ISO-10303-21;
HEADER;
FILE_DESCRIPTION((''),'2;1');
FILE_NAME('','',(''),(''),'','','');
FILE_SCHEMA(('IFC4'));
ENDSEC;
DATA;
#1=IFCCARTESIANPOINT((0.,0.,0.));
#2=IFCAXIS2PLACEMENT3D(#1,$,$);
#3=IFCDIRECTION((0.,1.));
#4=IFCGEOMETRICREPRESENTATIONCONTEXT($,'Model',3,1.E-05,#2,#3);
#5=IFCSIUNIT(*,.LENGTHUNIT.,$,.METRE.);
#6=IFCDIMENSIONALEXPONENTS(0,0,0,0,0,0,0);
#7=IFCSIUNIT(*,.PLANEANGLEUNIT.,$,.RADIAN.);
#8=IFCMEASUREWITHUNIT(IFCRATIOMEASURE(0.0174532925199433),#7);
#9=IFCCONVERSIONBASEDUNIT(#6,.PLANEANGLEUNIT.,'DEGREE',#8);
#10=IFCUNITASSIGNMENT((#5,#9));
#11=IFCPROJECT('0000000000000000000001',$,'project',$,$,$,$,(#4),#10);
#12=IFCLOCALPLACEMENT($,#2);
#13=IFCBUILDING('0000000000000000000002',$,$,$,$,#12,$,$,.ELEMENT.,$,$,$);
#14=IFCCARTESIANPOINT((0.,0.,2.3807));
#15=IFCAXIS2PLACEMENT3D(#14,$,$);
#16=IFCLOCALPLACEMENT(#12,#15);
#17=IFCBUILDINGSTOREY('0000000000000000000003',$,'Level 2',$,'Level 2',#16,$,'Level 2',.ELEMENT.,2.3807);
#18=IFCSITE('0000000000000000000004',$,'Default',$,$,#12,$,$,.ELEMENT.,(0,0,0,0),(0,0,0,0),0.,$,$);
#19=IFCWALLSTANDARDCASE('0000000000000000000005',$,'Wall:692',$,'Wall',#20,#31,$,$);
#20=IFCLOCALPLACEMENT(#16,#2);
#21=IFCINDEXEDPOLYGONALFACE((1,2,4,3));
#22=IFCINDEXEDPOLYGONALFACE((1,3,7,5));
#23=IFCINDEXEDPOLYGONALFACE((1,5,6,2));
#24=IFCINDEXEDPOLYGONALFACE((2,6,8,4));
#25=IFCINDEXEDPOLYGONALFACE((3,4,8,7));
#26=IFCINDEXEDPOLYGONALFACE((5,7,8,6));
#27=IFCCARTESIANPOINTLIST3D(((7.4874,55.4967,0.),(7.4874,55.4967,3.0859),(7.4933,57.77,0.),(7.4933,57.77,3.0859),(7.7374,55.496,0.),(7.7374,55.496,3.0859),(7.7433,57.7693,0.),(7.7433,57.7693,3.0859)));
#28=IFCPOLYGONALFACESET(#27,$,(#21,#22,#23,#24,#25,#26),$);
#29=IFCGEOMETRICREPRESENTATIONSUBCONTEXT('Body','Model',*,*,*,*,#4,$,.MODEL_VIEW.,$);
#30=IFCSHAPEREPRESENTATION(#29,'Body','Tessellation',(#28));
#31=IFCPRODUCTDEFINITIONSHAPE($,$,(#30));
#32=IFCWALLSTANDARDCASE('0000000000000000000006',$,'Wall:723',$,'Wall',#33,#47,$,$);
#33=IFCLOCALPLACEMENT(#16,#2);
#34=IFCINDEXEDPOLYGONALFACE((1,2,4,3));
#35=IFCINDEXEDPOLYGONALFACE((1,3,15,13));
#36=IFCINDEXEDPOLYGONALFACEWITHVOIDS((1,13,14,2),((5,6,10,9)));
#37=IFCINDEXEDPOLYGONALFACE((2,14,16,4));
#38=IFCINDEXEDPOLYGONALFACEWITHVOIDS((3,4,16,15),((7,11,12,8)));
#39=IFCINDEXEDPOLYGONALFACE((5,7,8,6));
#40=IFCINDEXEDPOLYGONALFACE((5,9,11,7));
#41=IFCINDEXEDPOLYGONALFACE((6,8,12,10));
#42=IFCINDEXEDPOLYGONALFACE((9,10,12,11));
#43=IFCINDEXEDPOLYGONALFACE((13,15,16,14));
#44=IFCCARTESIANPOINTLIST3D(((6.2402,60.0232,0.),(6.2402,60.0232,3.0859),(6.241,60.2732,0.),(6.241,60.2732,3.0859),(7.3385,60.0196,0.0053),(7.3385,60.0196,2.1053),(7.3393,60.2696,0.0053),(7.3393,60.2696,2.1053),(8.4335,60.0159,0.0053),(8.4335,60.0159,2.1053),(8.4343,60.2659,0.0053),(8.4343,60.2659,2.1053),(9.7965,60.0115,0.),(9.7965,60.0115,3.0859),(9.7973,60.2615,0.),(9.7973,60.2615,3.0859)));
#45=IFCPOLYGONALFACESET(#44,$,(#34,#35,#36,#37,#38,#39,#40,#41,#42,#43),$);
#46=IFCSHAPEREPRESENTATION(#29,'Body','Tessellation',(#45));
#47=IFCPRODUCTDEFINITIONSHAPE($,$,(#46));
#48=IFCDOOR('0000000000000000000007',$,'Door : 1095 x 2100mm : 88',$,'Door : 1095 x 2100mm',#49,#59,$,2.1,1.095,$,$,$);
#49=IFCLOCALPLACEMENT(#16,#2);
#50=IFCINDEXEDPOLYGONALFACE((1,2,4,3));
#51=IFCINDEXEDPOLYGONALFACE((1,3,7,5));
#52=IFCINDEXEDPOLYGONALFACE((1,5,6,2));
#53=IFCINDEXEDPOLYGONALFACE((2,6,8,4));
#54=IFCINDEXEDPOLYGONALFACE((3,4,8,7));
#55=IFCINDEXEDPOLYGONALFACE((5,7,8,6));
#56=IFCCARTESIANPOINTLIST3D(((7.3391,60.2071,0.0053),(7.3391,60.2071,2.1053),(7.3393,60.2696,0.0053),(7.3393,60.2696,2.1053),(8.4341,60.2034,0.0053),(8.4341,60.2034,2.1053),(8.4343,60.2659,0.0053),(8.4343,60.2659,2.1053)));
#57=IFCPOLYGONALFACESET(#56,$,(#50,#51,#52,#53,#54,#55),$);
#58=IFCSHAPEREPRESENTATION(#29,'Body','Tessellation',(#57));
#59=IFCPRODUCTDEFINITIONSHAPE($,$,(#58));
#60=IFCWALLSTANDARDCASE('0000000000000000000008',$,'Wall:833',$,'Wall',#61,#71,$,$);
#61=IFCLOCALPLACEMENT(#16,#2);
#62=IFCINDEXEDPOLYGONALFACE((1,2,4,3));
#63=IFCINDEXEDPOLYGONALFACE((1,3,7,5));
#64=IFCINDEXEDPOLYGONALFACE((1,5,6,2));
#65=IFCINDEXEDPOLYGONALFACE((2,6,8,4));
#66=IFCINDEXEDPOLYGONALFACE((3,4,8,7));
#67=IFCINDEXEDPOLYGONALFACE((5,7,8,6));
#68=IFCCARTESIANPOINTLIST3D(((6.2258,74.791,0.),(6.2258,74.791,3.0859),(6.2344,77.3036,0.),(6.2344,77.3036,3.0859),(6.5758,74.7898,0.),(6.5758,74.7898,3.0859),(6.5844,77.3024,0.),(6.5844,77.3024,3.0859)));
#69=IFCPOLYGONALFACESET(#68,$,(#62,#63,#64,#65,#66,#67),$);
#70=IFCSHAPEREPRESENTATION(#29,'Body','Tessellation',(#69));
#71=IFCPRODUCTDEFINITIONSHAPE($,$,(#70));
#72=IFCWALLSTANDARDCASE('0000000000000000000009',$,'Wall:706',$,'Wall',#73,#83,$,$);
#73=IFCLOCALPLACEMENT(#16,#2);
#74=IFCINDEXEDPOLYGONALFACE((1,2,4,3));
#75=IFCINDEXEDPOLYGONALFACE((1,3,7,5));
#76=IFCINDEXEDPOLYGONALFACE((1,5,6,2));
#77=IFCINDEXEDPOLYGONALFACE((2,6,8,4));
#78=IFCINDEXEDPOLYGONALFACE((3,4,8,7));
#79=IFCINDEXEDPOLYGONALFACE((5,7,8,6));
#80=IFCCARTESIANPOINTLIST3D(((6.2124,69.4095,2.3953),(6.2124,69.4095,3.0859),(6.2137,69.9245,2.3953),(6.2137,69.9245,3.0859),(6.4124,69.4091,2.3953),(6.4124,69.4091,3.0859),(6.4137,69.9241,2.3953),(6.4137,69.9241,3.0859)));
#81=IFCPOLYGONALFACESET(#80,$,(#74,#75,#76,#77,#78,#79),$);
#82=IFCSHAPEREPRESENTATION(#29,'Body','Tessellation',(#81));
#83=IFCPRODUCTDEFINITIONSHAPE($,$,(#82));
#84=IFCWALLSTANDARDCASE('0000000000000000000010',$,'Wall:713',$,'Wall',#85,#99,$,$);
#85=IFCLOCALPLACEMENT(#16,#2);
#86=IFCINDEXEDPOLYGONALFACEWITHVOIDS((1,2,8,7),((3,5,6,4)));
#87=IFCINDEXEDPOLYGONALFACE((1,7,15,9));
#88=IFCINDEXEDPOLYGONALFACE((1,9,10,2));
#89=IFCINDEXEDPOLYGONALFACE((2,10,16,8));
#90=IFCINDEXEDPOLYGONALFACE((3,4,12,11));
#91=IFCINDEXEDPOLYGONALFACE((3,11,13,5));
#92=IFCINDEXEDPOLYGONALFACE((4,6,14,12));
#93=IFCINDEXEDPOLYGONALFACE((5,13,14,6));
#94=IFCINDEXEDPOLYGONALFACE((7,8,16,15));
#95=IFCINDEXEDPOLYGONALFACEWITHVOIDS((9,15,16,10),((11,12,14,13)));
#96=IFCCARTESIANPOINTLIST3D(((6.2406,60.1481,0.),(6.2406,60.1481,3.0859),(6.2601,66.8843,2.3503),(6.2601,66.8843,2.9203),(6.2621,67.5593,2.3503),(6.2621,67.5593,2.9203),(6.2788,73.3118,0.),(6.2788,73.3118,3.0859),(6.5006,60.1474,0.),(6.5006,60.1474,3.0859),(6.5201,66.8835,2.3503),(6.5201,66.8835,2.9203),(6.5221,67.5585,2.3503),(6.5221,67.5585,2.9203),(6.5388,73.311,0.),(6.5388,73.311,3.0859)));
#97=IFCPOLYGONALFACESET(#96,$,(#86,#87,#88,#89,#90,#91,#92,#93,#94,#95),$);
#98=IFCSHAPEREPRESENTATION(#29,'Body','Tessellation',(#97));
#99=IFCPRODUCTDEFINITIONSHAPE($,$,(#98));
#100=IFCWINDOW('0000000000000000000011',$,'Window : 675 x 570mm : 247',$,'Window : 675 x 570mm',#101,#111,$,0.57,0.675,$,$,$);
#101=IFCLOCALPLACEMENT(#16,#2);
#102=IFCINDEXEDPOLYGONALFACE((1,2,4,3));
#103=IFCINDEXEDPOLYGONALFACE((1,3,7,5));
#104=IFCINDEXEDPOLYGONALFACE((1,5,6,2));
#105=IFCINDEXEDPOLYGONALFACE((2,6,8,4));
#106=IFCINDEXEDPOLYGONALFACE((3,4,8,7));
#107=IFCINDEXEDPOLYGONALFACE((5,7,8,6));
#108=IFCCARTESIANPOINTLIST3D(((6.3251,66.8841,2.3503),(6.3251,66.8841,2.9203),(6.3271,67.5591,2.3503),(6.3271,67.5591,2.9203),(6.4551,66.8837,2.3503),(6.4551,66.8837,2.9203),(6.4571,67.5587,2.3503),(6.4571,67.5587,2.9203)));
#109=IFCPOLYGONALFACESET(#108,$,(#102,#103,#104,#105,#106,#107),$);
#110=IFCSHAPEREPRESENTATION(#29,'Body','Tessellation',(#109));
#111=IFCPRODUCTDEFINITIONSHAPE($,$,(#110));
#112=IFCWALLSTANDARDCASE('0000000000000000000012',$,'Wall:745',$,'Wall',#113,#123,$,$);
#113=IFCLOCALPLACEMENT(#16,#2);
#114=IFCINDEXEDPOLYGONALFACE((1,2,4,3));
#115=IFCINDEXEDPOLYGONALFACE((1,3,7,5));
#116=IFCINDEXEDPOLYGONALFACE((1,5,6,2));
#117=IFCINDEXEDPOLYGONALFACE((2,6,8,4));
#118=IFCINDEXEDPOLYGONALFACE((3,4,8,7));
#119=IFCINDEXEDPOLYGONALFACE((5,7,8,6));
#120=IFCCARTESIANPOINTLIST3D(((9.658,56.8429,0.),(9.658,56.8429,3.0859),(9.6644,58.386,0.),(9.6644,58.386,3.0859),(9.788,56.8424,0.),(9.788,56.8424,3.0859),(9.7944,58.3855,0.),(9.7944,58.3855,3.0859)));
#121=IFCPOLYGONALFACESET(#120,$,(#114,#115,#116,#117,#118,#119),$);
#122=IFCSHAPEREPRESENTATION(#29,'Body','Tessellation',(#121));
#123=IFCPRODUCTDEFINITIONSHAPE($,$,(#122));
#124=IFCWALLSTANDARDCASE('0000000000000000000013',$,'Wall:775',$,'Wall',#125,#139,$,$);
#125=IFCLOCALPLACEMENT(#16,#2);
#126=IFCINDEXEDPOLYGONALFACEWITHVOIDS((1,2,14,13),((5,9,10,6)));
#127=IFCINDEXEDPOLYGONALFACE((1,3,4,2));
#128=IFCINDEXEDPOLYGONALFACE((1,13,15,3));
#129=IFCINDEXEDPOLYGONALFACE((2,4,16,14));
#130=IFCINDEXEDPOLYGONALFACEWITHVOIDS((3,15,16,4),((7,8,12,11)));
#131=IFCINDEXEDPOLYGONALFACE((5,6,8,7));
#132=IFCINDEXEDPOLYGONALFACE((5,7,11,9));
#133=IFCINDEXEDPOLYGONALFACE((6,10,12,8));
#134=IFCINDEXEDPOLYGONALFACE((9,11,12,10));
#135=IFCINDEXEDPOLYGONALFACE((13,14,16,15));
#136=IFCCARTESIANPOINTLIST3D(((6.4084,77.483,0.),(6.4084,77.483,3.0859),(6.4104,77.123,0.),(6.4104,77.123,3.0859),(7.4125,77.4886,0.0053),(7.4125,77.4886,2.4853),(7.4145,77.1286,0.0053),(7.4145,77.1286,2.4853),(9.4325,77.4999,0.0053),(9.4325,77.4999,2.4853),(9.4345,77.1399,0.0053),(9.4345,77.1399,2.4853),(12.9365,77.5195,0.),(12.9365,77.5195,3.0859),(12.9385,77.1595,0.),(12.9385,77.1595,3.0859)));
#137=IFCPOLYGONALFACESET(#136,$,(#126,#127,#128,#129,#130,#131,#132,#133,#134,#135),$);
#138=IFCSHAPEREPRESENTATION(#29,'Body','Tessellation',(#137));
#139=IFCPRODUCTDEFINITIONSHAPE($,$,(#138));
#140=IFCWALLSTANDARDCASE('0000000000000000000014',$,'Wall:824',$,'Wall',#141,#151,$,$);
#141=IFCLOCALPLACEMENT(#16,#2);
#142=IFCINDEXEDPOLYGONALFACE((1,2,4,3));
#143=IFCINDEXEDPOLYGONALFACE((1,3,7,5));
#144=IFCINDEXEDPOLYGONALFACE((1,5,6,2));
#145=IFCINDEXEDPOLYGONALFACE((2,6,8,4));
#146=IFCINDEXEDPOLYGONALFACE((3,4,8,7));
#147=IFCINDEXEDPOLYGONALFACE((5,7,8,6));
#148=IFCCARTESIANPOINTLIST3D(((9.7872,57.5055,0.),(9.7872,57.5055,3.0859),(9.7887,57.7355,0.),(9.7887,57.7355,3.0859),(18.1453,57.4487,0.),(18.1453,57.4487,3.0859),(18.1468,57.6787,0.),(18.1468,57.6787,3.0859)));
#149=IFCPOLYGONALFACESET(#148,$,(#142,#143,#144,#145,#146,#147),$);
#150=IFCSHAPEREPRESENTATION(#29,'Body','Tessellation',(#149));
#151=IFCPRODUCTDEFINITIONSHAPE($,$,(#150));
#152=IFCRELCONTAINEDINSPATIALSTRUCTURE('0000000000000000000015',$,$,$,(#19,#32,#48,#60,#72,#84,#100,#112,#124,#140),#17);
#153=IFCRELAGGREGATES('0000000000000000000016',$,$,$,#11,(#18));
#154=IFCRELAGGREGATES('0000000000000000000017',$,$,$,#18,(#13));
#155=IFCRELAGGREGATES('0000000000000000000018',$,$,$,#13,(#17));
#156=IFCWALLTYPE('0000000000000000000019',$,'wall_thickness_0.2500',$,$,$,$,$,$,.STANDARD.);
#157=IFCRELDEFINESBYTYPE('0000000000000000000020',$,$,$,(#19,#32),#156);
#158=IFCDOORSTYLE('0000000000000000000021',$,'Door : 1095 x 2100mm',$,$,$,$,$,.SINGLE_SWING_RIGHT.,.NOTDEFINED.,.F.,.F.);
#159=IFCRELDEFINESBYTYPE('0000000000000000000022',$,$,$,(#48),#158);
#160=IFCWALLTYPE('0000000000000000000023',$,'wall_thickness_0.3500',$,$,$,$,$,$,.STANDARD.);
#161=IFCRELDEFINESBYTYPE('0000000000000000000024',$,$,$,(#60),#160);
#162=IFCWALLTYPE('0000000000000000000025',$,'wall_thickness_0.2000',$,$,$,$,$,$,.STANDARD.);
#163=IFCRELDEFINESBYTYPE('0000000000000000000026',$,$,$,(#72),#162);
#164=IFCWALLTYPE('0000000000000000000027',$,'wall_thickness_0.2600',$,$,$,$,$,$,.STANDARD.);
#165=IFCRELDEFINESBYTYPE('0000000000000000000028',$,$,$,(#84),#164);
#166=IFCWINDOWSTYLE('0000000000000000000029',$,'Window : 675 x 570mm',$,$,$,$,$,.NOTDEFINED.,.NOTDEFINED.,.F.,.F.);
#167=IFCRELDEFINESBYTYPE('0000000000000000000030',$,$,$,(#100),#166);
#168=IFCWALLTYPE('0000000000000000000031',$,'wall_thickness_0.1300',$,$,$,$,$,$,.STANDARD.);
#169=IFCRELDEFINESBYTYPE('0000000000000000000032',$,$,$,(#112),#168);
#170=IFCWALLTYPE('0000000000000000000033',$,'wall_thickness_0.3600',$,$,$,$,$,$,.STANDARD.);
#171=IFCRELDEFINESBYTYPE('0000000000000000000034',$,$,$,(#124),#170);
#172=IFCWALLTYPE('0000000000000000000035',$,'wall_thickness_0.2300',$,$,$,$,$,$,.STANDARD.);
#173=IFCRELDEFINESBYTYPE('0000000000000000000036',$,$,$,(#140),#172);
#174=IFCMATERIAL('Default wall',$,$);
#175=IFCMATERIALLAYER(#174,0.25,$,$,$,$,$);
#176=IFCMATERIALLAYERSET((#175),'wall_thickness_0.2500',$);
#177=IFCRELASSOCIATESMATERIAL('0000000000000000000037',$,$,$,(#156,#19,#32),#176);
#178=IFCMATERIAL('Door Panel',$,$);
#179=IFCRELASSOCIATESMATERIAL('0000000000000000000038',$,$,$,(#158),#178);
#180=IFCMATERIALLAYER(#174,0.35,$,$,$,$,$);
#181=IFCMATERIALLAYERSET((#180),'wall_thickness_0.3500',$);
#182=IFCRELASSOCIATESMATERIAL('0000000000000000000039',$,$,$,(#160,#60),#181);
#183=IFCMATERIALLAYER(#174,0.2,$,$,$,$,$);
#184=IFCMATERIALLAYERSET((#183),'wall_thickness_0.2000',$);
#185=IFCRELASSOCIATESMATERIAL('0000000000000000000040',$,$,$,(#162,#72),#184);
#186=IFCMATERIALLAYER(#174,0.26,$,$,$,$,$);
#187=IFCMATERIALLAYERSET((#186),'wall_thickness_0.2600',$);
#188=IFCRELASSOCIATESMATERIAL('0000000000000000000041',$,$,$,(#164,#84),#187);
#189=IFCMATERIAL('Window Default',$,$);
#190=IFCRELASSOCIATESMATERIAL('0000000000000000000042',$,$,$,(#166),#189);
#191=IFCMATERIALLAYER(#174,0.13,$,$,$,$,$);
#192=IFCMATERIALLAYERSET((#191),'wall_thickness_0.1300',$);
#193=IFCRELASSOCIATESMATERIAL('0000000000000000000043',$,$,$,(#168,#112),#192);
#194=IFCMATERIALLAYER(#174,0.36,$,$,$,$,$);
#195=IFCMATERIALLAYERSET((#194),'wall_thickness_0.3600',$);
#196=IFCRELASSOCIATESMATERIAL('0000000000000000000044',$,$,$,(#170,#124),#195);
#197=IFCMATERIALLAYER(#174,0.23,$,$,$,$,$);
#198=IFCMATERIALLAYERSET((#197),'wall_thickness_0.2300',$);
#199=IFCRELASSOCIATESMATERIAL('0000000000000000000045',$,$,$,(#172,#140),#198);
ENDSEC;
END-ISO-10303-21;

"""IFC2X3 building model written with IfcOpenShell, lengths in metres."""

from ifc_helpers import new_model, entity, si_unit, converted_unit, direction, frame, frame_2d, origin, origin_2d_with_axis, place, context, subcontext, project, spatial, polyline, rectangle, outline, extrude, source, transform, mapped, material, layer, layer_set, layer_usage, type_object, type_shapes, element, fill, save


model = new_model("IFC2X3")

# Units and contexts
model_context = context("Model", 3, precision=1e-05, world=origin(), true_north=direction((0.0, 1.0)))
body_context = subcontext(model_context, "Body", "Model", "MODEL_VIEW")
ifc_project = project(units=[si_unit("LENGTHUNIT", "METRE"), converted_unit("PLANEANGLEUNIT", "DEGREE", entity("IfcRatioMeasure", 0.0174532925199433), si_unit("PLANEANGLEUNIT", "RADIAN"), dimensions=[0, 0, 0, 0, 0, 0, 0])], contexts=[model_context])

# Site, building, storey
placement_1 = place(None, origin())
site = spatial("IfcSite", under=ifc_project, at=placement_1, Name="Default", CompositionType="ELEMENT", RefLatitude=(0, 0, 0, 0), RefLongitude=(0, 0, 0, 0), RefElevation=0.0)
building = spatial("IfcBuilding", under=site, at=placement_1, CompositionType="ELEMENT")
storey_placement = place(placement_1, frame((0.0, 0.0, 2.3807)))
storey = spatial("IfcBuildingStorey", under=building, at=storey_placement, Name="Level 2", ObjectType="Level 2", LongName="Level 2", CompositionType="ELEMENT", Elevation=2.3807)

# Wall
ifc_material_1 = material(Name="Default wall")
ifc_layer_1 = layer(ifc_material_1, 0.25)
ifc_layer_set_1 = layer_set([ifc_layer_1], Name="wall_thickness_0.2500")
ifc_layer_usage_1 = layer_usage(ifc_layer_set_1, "AXIS2", "POSITIVE", -0.125)
wall_type_1 = type_object("IfcWallType", Name="wall_thickness_0.2500", PredefinedType="STANDARD", material=ifc_layer_set_1)
wall_1_placement = place(storey_placement, frame((7.6183, 57.7697, 0.0), z_axis=(0.0, 0.0, 1.0), x_axis=(-0.002626, -0.999997, 0.0)))
element("IfcWallStandardCase", 1, at=wall_1_placement, inside=storey, type_object=wall_type_1, material=ifc_layer_usage_1, Name="Wall:692", ObjectType="Wall", context=body_context, shape_type="SweptSolid", body=[
    extrude(outline(polyline([(2.2733, -0.125), (2.2733, 0.125), (0.0, 0.125), (0.0, -0.125), (2.2733, -0.125)])), origin(), (0.0, 0.0, 1.0), 3.0859),
])

# Wall, opening, door
wall_2_placement = place(storey_placement, frame((6.2406, 60.1482, 0.0), z_axis=(0.0, 0.0, 1.0), x_axis=(0.999995, -0.003298, 0.0)))
wall_2 = element("IfcWallStandardCase", 2, at=wall_2_placement, inside=storey, type_object=wall_type_1, material=ifc_layer_usage_1, Name="Wall:723", ObjectType="Wall", context=body_context, shape_type="SweptSolid", body=[
    extrude(outline(polyline([(3.5563, -0.125), (3.5563, 0.125), (0.0, 0.125), (0.0, -0.125), (3.5563, -0.125)])), origin(), (0.0, 0.0, 1.0), 3.0859),
])
opening_1_placement = place(wall_2_placement, frame((1.0983, -0.125, 0.0053)))
opening_1 = element("IfcOpeningElement", 3, at=opening_1_placement, cuts=wall_2, ObjectType="Opening", context=body_context, shape_type="SweptSolid", body=[
    extrude(rectangle(XDim=1.095, YDim=2.1, at=frame_2d((1.05, 0.5475), x_axis=(0.0, 1.0))), frame((0.0, 0.0, 0.0), z_axis=(0.0, 1.0, 0.0), x_axis=(0.0, 0.0, 1.0)), (0.0, 0.0, 1.0), 0.25),
])
ifc_material_2 = material(Name="Door Panel")
door_style = type_object("IfcDoorStyle", Name="Door : 1095 x 2100mm", ConstructionType="NOTDEFINED", OperationType="SINGLE_SWING_RIGHT", ParameterTakesPrecedence=False, Sizeable=False, material=ifc_material_2)
shared_shape_1 = source(origin(), body_context, "Body", "SweptSolid", [
    extrude(rectangle(XDim=0.0625, YDim=1.095, at=origin_2d_with_axis()), frame((0.5475, 0.2188, 0.0), z_axis=(0.0, 0.0, 1.0), x_axis=(0.0, 1.0, 0.0)), (0.0, 0.0, 1.0), 2.1),
])
type_shapes(door_style, [shared_shape_1])
door_placement = place(opening_1_placement, origin())
door = element("IfcDoor", 4, at=door_placement, inside=storey, type_object=door_style, Name="Door : 1095 x 2100mm : 88", ObjectType="Door : 1095 x 2100mm", OverallHeight=2.1, OverallWidth=1.095, context=body_context, shape_type="MappedRepresentation", body=[
    mapped(shared_shape_1, transform((0.0, 0.0, 0.0), scale=1.0)),
])
fill(opening_1, door)

# Walls
ifc_layer_2 = layer(ifc_material_1, 0.35)
ifc_layer_set_2 = layer_set([ifc_layer_2], Name="wall_thickness_0.3500")
ifc_layer_usage_2 = layer_usage(ifc_layer_set_2, "AXIS2", "POSITIVE", -0.175)
wall_type_2 = type_object("IfcWallType", Name="wall_thickness_0.3500", PredefinedType="STANDARD", material=ifc_layer_set_2)
wall_3_placement = place(storey_placement, frame((6.4094, 77.303, 0.0), z_axis=(0.0, 0.0, 1.0), x_axis=(-0.003432, -0.999994, 0.0)))
element("IfcWallStandardCase", 5, at=wall_3_placement, inside=storey, type_object=wall_type_2, material=ifc_layer_usage_2, Name="Wall:833", ObjectType="Wall", context=body_context, shape_type="SweptSolid", body=[
    extrude(outline(polyline([(2.5126, -0.175), (2.5126, 0.175), (0.0, 0.175), (0.0, -0.175), (2.5126, -0.175)])), origin(), (0.0, 0.0, 1.0), 3.0859),
])
ifc_layer_3 = layer(ifc_material_1, 0.2)
ifc_layer_set_3 = layer_set([ifc_layer_3], Name="wall_thickness_0.2000")
ifc_layer_usage_3 = layer_usage(ifc_layer_set_3, "AXIS2", "POSITIVE", -0.1)
wall_type_3 = type_object("IfcWallType", Name="wall_thickness_0.2000", PredefinedType="STANDARD", material=ifc_layer_set_3)
placement_2 = place(placement_1, frame((0.0, 0.0, 4.776)))
wall_4_placement = place(placement_2, frame((6.3137, 69.9243, 0.0), z_axis=(0.0, 0.0, 1.0), x_axis=(-0.002418, -0.999997, 0.0)))
element("IfcWallStandardCase", 6, at=wall_4_placement, inside=storey, type_object=wall_type_3, material=ifc_layer_usage_3, Name="Wall:706", ObjectType="Wall", context=body_context, shape_type="SweptSolid", body=[
    extrude(outline(polyline([(0.515, -0.1), (0.515, 0.1), (0.0, 0.1), (0.0, -0.1), (0.515, -0.1)])), origin(), (0.0, 0.0, 1.0), 0.6906),
])

# Wall, opening, window
ifc_layer_4 = layer(ifc_material_1, 0.26)
ifc_layer_set_4 = layer_set([ifc_layer_4], Name="wall_thickness_0.2600")
ifc_layer_usage_4 = layer_usage(ifc_layer_set_4, "AXIS2", "POSITIVE", -0.13)
wall_type_4 = type_object("IfcWallType", Name="wall_thickness_0.2600", PredefinedType="STANDARD", material=ifc_layer_set_4)
wall_5_placement = place(storey_placement, frame((6.4088, 73.3114, 0.0), z_axis=(0.0, 0.0, 1.0), x_axis=(-0.002903, -0.999996, 0.0)))
wall_5 = element("IfcWallStandardCase", 7, at=wall_5_placement, inside=storey, type_object=wall_type_4, material=ifc_layer_usage_4, Name="Wall:713", ObjectType="Wall", context=body_context, shape_type="SweptSolid", body=[
    extrude(outline(polyline([(13.1637, -0.13), (13.1637, 0.13), (0.0, 0.13), (0.0, -0.13), (13.1637, -0.13)])), origin(), (0.0, 0.0, 1.0), 3.0859),
])
opening_2_placement = place(wall_5_placement, frame((5.7525, -0.13, 2.3503)))
opening_2 = element("IfcOpeningElement", 8, at=opening_2_placement, cuts=wall_5, ObjectType="Opening", context=body_context, shape_type="SweptSolid", body=[
    extrude(rectangle(XDim=0.675, YDim=0.57, at=frame_2d((0.285, 0.3375), x_axis=(0.0, 1.0))), frame((0.0, 0.0, 0.0), z_axis=(0.0, 1.0, 0.0), x_axis=(0.0, 0.0, 1.0)), (0.0, 0.0, 1.0), 0.26),
])
ifc_material_3 = material(Name="Window Default")
window_style = type_object("IfcWindowStyle", Name="Window : 675 x 570mm", ConstructionType="NOTDEFINED", OperationType="NOTDEFINED", ParameterTakesPrecedence=False, Sizeable=False, material=ifc_material_3)
shared_shape_2 = source(origin(), body_context, "Body", "SweptSolid", [
    extrude(rectangle(XDim=0.13, YDim=0.675, at=origin_2d_with_axis()), frame((0.3375, 0.13, 0.0), z_axis=(0.0, 0.0, 1.0), x_axis=(0.0, 1.0, 0.0)), (0.0, 0.0, 1.0), 0.57),
])
type_shapes(window_style, [shared_shape_2])
window_placement = place(opening_2_placement, origin())
window = element("IfcWindow", 9, at=window_placement, inside=storey, type_object=window_style, Name="Window : 675 x 570mm : 247", ObjectType="Window : 675 x 570mm", OverallHeight=0.57, OverallWidth=0.675, context=body_context, shape_type="MappedRepresentation", body=[
    mapped(shared_shape_2, transform((0.0, 0.0, 0.0), scale=1.0)),
])
fill(opening_2, window)

# Wall
ifc_layer_5 = layer(ifc_material_1, 0.13)
ifc_layer_set_5 = layer_set([ifc_layer_5], Name="wall_thickness_0.1300")
ifc_layer_usage_5 = layer_usage(ifc_layer_set_5, "AXIS2", "POSITIVE", -0.065)
wall_type_5 = type_object("IfcWallType", Name="wall_thickness_0.1300", PredefinedType="STANDARD", material=ifc_layer_set_5)
wall_6_placement = place(storey_placement, frame((9.7294, 58.3858, 0.0), z_axis=(0.0, 0.0, 1.0), x_axis=(-0.004138, -0.999991, 0.0)))
element("IfcWallStandardCase", 10, at=wall_6_placement, inside=storey, type_object=wall_type_5, material=ifc_layer_usage_5, Name="Wall:745", ObjectType="Wall", context=body_context, shape_type="SweptSolid", body=[
    extrude(outline(polyline([(1.5431, -0.065), (1.5431, 0.065), (0.0, 0.065), (0.0, -0.065), (1.5431, -0.065)])), origin(), (0.0, 0.0, 1.0), 3.0859),
])

# Wall, opening
ifc_layer_6 = layer(ifc_material_1, 0.36)
ifc_layer_set_6 = layer_set([ifc_layer_6], Name="wall_thickness_0.3600")
ifc_layer_usage_6 = layer_usage(ifc_layer_set_6, "AXIS2", "POSITIVE", -0.18)
wall_type_6 = type_object("IfcWallType", Name="wall_thickness_0.3600", PredefinedType="STANDARD", material=ifc_layer_set_6)
wall_7_placement = place(storey_placement, frame((6.4094, 77.303, 0.0), z_axis=(0.0, 0.0, 1.0), x_axis=(0.999984, 0.005589, 0.0)))
wall_7 = element("IfcWallStandardCase", 11, at=wall_7_placement, inside=storey, type_object=wall_type_6, material=ifc_layer_usage_6, Name="Wall:775", ObjectType="Wall", context=body_context, shape_type="SweptSolid", body=[
    extrude(outline(polyline([(6.5282, -0.18), (6.5282, 0.18), (0.0, 0.18), (0.0, -0.18), (6.5282, -0.18)])), origin(), (0.0, 0.0, 1.0), 3.0859),
])
opening_3_placement = place(wall_7_placement, frame((1.0041, -0.18, 0.0053)))
element("IfcOpeningElement", 12, at=opening_3_placement, cuts=wall_7, ObjectType="Opening", context=body_context, shape_type="SweptSolid", body=[
    extrude(rectangle(XDim=2.02, YDim=2.48, at=frame_2d((1.24, 1.01), x_axis=(0.0, 1.0))), frame((0.0, 0.0, 0.0), z_axis=(0.0, 1.0, 0.0), x_axis=(0.0, 0.0, 1.0)), (0.0, 0.0, 1.0), 0.36),
])

# Wall
ifc_layer_7 = layer(ifc_material_1, 0.23)
ifc_layer_set_7 = layer_set([ifc_layer_7], Name="wall_thickness_0.2300")
ifc_layer_usage_7 = layer_usage(ifc_layer_set_7, "AXIS2", "POSITIVE", -0.115)
wall_type_7 = type_object("IfcWallType", Name="wall_thickness_0.2300", PredefinedType="STANDARD", material=ifc_layer_set_7)
wall_8_placement = place(storey_placement, frame((9.788, 57.6205, 0.0), z_axis=(0.0, 0.0, 1.0), x_axis=(0.999977, -0.006795, 0.0)))
element("IfcWallStandardCase", 13, at=wall_8_placement, inside=storey, type_object=wall_type_7, material=ifc_layer_usage_7, Name="Wall:824", ObjectType="Wall", context=body_context, shape_type="SweptSolid", body=[
    extrude(outline(polyline([(8.3583, -0.115), (8.3583, 0.115), (0.0, 0.115), (0.0, -0.115), (8.3583, -0.115)])), origin(), (0.0, 0.0, 1.0), 3.0859),
])

save(model, "model.ifc")
